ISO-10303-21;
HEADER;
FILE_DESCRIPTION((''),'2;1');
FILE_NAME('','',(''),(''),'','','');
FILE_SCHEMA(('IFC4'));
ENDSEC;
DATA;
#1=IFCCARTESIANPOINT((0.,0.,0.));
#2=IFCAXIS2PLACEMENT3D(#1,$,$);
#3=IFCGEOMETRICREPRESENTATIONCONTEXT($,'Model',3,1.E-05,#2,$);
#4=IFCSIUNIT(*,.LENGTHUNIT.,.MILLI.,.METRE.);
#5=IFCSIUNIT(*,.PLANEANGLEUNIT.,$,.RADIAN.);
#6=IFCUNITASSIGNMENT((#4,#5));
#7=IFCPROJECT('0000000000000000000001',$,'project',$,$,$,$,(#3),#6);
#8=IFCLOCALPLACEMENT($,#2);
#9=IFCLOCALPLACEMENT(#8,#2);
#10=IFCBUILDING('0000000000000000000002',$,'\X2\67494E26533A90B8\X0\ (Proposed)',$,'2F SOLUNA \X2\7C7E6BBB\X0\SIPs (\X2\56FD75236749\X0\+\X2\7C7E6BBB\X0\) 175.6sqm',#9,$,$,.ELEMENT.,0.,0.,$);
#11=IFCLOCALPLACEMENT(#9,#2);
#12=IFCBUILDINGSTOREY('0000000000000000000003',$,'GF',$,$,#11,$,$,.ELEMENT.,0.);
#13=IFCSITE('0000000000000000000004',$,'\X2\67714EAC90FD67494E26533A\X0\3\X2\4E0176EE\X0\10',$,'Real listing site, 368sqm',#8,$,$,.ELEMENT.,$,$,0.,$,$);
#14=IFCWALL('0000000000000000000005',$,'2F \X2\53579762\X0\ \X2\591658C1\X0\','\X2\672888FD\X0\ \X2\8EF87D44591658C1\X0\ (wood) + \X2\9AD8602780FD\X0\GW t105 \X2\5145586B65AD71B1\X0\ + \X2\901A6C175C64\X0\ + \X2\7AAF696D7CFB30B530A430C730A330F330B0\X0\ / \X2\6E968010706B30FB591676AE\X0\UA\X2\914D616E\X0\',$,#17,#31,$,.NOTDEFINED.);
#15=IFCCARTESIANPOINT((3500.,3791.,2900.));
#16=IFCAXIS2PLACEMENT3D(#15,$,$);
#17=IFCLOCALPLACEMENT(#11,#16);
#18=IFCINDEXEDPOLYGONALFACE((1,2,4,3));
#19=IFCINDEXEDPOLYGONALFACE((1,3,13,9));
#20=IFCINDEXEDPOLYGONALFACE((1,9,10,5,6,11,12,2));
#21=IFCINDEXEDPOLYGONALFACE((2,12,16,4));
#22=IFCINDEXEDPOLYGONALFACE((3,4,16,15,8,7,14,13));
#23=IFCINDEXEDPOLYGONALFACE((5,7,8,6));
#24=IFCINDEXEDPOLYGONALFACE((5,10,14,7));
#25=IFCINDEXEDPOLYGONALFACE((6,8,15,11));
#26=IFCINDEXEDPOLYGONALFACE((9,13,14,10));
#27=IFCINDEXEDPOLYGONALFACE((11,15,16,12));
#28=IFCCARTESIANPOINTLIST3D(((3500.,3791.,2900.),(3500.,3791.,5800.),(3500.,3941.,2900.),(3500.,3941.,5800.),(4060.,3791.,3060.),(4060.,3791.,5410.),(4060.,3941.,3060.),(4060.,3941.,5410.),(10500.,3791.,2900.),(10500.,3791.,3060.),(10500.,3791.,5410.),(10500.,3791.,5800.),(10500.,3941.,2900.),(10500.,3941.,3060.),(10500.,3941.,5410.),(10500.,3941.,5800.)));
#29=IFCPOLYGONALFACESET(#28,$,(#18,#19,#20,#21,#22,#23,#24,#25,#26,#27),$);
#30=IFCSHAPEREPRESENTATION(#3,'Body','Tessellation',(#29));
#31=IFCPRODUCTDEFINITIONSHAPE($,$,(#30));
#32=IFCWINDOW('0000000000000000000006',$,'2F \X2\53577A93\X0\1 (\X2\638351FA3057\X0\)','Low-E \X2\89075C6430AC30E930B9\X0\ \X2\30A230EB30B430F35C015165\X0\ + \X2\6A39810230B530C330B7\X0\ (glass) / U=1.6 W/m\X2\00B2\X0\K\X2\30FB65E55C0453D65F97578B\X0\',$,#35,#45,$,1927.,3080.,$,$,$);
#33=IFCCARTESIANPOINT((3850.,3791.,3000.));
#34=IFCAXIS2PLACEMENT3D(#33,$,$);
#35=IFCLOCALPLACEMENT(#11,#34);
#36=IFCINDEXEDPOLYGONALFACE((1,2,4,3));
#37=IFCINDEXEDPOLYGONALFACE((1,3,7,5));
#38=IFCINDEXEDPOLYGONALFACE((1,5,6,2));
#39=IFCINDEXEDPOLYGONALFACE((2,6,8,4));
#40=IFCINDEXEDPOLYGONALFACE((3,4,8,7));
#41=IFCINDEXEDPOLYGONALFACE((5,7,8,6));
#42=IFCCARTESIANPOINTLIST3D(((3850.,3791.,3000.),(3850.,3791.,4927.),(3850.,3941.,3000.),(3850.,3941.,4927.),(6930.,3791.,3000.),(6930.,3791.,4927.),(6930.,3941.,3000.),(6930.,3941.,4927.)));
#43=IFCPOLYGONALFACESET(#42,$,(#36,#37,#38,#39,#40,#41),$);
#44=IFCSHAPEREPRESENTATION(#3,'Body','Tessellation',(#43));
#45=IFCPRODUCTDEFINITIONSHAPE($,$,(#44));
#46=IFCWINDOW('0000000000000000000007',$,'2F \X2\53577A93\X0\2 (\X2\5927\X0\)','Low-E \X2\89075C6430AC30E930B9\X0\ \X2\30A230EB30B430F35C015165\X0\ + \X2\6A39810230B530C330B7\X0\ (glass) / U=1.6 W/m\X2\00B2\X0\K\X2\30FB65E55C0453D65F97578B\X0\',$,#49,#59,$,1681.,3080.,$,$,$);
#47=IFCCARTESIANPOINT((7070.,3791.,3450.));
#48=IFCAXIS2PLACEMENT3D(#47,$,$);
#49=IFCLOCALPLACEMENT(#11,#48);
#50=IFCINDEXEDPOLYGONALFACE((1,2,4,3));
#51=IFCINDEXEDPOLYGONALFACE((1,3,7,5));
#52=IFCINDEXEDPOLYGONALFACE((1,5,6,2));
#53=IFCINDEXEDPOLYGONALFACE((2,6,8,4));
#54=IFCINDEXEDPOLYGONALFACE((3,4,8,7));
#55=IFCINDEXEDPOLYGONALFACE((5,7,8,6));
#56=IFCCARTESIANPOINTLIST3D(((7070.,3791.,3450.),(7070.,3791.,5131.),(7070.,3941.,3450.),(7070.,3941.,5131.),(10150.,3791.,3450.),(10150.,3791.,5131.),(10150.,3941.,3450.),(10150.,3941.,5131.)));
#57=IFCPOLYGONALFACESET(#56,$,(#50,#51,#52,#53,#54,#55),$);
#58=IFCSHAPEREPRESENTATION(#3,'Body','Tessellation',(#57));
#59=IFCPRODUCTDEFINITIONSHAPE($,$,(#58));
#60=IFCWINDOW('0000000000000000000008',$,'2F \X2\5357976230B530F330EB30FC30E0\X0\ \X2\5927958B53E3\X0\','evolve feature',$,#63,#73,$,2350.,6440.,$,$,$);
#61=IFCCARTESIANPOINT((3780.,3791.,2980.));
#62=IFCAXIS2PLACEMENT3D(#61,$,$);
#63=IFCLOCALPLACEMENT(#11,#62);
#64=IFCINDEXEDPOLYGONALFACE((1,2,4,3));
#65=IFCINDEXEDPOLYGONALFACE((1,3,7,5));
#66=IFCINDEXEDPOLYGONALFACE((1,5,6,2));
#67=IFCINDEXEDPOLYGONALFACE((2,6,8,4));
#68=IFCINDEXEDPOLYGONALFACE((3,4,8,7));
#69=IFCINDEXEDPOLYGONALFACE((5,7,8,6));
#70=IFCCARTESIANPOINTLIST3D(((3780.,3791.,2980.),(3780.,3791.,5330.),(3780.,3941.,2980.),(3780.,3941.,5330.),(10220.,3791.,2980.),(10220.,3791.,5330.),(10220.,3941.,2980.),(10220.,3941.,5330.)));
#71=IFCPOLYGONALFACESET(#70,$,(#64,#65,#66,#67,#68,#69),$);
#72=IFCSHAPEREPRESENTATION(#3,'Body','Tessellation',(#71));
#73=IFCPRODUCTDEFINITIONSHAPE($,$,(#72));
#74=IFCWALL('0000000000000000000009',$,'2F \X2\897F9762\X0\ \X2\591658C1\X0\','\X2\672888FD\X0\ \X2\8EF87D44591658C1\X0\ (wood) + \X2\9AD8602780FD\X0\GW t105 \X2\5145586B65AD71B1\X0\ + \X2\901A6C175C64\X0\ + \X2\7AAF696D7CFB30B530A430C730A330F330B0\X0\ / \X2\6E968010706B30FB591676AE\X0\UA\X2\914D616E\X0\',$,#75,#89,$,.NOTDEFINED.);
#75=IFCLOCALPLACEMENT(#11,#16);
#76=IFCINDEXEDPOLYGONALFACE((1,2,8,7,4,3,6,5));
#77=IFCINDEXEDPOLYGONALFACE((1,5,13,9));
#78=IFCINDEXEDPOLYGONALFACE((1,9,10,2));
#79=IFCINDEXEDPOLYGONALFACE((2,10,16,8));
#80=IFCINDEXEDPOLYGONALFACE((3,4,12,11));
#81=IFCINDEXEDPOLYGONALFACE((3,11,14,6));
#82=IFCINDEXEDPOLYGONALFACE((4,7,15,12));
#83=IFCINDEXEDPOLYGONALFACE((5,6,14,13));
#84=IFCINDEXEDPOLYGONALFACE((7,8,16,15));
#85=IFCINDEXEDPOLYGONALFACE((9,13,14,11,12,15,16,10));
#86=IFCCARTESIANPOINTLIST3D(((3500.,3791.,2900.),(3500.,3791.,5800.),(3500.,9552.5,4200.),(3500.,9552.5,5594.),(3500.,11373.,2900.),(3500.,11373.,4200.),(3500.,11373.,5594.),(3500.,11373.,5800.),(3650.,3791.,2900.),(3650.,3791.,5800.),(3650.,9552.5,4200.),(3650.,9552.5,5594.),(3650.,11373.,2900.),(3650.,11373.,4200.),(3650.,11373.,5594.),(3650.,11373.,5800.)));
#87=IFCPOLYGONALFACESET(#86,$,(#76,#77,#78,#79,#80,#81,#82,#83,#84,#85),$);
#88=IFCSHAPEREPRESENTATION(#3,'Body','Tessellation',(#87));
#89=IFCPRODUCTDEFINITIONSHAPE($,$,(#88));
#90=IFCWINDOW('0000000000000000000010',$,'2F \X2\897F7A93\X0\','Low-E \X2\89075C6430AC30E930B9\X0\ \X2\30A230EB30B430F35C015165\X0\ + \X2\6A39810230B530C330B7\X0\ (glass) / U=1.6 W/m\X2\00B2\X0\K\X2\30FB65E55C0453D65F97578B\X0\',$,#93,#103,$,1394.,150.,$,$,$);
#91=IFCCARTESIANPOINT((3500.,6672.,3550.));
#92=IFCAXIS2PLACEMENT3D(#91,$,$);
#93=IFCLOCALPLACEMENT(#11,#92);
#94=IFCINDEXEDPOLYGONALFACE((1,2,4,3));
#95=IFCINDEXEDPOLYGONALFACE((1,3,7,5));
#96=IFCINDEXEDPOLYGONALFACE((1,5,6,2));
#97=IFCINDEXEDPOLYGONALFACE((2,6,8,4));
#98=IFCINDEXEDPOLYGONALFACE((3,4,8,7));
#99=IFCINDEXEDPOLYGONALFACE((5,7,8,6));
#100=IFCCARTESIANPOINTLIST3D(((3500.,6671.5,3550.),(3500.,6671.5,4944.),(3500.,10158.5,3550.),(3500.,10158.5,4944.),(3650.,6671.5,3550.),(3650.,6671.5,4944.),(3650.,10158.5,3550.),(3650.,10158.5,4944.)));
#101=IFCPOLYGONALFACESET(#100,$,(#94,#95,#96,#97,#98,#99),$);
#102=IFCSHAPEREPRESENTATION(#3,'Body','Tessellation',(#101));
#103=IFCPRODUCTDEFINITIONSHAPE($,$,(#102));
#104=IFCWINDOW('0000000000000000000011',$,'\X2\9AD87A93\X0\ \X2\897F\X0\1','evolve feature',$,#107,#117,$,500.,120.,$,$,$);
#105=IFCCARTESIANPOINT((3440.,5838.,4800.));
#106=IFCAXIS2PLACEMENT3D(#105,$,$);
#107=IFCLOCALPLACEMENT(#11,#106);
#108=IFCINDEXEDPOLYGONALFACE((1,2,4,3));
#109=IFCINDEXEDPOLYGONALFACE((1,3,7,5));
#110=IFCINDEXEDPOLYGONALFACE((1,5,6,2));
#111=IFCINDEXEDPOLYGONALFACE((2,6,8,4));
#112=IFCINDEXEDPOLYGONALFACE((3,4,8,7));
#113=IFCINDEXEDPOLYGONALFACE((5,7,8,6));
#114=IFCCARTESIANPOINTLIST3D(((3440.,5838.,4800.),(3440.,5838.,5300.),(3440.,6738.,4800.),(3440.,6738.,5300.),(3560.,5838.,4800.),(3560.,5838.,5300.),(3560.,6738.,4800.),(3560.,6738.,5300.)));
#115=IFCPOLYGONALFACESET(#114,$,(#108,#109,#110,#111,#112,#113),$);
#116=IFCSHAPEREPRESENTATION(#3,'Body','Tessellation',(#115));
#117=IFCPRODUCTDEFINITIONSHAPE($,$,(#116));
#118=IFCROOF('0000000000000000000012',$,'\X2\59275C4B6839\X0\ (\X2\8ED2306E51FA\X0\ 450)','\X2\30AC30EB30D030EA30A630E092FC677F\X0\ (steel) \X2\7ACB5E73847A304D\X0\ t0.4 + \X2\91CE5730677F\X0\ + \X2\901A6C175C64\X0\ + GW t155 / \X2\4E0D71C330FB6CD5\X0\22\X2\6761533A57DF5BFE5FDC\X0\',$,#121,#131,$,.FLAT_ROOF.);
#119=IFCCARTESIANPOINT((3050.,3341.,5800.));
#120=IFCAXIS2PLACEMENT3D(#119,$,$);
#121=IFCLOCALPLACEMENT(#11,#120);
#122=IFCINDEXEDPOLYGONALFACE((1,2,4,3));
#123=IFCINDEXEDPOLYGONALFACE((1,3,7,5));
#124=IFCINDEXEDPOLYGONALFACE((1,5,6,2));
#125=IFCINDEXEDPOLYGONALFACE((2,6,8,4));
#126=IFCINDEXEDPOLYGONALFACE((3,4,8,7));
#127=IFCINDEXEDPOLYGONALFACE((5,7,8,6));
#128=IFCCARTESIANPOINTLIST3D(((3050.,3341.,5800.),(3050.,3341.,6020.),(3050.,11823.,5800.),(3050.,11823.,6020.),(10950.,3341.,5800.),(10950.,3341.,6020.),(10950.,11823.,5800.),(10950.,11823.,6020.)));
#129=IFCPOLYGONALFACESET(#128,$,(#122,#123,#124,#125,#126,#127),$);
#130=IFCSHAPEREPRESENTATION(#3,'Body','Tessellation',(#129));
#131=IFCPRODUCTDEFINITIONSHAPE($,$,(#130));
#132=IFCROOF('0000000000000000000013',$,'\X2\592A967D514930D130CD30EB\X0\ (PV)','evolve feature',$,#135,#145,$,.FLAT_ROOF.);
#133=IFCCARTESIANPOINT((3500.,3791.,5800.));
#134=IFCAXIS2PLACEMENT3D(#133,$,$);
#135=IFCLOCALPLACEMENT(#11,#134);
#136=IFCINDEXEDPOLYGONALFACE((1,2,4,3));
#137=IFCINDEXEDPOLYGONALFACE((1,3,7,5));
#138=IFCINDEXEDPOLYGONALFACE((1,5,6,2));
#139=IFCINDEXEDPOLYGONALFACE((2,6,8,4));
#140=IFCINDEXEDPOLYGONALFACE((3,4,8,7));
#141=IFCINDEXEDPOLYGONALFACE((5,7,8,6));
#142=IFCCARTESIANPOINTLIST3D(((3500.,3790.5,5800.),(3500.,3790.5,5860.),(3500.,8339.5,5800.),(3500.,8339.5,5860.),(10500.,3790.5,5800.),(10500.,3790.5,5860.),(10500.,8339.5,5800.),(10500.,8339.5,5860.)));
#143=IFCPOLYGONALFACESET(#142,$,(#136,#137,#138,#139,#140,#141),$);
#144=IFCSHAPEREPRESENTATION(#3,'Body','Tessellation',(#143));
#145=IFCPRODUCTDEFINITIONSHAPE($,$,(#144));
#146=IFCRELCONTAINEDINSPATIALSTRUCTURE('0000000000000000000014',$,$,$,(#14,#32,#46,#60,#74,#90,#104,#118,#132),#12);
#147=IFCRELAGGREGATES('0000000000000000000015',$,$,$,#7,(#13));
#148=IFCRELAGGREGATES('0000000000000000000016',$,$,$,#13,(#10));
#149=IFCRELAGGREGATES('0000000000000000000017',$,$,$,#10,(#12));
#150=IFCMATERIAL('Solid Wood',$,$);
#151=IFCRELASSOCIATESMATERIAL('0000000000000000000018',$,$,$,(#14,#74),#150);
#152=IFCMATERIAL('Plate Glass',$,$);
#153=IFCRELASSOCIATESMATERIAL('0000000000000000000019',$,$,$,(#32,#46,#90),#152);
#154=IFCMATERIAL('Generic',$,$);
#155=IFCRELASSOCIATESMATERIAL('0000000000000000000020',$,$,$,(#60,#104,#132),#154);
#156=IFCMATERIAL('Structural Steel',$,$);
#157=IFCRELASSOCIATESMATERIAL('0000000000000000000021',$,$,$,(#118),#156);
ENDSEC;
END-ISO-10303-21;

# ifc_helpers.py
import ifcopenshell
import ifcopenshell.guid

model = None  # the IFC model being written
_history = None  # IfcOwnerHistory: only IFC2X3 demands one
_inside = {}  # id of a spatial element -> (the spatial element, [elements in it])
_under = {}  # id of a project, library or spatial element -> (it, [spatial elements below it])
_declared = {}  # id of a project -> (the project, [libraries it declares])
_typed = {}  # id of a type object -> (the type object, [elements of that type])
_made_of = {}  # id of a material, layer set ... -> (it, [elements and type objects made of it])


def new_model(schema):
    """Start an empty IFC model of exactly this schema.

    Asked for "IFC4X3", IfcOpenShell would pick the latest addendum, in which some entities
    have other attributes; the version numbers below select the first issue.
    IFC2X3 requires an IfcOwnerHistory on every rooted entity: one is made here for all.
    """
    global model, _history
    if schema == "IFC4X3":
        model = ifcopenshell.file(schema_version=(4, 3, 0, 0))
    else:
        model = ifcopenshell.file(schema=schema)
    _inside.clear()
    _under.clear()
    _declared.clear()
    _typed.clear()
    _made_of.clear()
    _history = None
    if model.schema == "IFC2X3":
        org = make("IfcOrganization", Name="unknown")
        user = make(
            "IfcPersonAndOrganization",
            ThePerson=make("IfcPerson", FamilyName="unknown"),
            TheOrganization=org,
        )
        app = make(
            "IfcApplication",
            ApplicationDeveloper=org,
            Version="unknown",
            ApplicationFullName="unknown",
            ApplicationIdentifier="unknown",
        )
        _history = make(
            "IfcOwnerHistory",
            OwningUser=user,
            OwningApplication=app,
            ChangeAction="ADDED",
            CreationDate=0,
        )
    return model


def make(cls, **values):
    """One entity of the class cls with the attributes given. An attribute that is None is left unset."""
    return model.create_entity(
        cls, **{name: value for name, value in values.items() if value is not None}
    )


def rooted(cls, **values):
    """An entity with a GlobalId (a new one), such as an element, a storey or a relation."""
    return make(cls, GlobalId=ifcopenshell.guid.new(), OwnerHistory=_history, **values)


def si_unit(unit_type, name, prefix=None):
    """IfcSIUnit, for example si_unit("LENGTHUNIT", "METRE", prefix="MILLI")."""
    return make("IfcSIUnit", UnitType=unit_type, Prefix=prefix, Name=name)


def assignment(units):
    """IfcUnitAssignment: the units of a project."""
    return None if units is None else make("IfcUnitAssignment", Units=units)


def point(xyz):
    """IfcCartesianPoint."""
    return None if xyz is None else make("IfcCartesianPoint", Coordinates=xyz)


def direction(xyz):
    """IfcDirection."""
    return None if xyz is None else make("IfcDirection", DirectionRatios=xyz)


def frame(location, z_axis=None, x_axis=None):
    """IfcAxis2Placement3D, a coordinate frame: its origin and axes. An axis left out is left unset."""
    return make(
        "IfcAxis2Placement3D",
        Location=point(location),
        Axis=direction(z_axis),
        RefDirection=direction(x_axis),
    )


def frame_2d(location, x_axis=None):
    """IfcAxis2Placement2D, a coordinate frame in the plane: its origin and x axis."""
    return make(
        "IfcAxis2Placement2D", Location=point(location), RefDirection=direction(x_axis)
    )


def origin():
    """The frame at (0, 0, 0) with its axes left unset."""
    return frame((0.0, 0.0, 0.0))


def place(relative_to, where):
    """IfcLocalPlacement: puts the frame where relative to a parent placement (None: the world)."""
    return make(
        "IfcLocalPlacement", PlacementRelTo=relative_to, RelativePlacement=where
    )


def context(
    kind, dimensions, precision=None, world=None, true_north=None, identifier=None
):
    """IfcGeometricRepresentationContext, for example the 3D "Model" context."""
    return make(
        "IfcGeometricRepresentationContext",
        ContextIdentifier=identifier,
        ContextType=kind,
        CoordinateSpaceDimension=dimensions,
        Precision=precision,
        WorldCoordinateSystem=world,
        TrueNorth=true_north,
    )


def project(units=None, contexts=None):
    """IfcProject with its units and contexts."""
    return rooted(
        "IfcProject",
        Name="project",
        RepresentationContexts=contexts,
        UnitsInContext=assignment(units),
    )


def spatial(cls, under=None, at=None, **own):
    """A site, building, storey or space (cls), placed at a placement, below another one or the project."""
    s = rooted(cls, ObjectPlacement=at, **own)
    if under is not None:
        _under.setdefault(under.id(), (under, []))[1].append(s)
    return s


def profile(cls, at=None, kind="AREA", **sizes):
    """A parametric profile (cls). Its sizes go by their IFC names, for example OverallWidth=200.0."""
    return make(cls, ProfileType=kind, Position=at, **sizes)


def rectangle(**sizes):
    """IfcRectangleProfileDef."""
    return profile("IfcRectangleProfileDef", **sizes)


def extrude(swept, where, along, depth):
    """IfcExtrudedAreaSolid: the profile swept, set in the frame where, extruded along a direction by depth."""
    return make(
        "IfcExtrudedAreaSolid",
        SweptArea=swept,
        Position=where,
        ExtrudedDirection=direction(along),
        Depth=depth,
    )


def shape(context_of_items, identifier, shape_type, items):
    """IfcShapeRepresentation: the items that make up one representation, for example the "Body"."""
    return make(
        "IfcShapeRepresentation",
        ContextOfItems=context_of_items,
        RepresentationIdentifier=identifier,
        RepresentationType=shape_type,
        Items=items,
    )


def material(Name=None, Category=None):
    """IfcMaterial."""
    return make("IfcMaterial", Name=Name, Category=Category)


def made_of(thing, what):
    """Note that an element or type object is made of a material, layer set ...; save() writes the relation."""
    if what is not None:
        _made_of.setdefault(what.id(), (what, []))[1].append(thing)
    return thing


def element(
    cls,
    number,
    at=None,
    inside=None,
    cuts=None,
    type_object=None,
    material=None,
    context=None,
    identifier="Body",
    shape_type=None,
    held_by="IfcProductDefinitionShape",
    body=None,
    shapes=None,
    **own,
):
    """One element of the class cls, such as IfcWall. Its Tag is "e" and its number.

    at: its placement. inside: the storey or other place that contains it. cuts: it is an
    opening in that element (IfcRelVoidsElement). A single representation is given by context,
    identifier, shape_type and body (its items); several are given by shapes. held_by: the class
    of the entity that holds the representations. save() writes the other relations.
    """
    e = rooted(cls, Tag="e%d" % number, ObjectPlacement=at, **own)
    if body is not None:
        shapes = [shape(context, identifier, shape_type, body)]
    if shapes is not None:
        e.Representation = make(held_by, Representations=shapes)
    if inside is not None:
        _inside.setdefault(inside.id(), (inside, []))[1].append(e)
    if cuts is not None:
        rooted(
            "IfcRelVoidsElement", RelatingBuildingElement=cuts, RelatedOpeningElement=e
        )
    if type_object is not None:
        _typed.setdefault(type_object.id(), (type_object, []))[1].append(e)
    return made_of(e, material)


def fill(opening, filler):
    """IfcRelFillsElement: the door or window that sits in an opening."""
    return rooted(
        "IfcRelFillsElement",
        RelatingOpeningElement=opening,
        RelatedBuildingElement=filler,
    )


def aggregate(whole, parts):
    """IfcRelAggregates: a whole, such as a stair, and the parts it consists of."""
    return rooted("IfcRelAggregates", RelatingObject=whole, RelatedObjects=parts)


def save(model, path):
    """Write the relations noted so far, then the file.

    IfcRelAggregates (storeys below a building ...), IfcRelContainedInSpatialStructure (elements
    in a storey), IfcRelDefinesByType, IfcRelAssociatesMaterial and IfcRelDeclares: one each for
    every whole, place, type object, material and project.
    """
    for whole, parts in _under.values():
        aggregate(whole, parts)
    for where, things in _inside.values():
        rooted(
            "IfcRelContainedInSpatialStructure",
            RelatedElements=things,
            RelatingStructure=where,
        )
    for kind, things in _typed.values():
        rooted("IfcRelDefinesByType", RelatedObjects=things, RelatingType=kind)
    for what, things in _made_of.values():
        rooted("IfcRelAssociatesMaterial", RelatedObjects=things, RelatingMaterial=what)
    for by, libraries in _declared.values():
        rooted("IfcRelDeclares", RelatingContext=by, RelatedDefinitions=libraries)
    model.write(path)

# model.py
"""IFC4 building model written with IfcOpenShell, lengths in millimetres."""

from ifc_helpers import new_model, si_unit, frame, frame_2d, origin, place, context, project, spatial, rectangle, extrude, material, element, fill, save


model = new_model("IFC4")

# Units and contexts
model_context = context("Model", 3, precision=1e-05, world=origin())
ifc_project = project(units=[si_unit("LENGTHUNIT", "METRE", prefix="MILLI"), si_unit("PLANEANGLEUNIT", "RADIAN")], contexts=[model_context])

# Site, building, storey
site_placement = place(None, origin())
site = spatial("IfcSite", under=ifc_project, at=site_placement, Name="東京都杉並区3丁目10", ObjectType="Real listing site, 368sqm", CompositionType="ELEMENT", RefElevation=0.0)
building_placement = place(site_placement, origin())
building = spatial("IfcBuilding", under=site, at=building_placement, Name="杉並区邸 (Proposed)", ObjectType="2F SOLUNA 籾殻SIPs (国産杉+籾殻) 175.6sqm", CompositionType="ELEMENT", ElevationOfRefHeight=0.0, ElevationOfTerrain=0.0)
storey_placement = place(building_placement, origin())
storey = spatial("IfcBuildingStorey", under=building, at=storey_placement, Name="GF", CompositionType="ELEMENT", Elevation=0.0)

# Shared definitions
ifc_material_1 = material(Name="Solid Wood")
ifc_material_2 = material(Name="Generic")

# Shared definitions
ifc_material_3 = material(Name="Plate Glass")

# Walls, openings, windows
wall_1_placement = place(storey_placement, frame((3500.0, 3791.0, 2900.0)))
wall_1 = element("IfcWall", 1, at=wall_1_placement, inside=storey, material=ifc_material_1, Name="2F 南面 外壁", Description="木製 軸組外壁 (wood) + 高性能GW t105 充填断熱 + 通気層 + 窯業系サイディング / 準耐火・外皮UA配慮", PredefinedType="NOTDEFINED", context=model_context, shape_type="SweptSolid", body=[
    extrude(rectangle(XDim=7000.0, YDim=150.0, at=frame_2d((3500.0, 75.0))), frame((3500.0, 3791.0, 2900.0)), (0.0, 0.0, 1.0), 2900.0),
])
opening_1_placement = place(storey_placement, frame((3850.0, 3791.0, 3000.0)))
opening_1 = element("IfcOpeningElement", 2, at=opening_1_placement, cuts=wall_1, PredefinedType="NOTDEFINED", context=model_context, shape_type="SweptSolid", body=[
    extrude(rectangle(XDim=3080.0, YDim=150.0, at=frame_2d((1540.0, 75.0))), frame((3850.0, 3791.0, 3000.0)), (0.0, 0.0, 1.0), 1927.0),
])
opening_2_placement = place(storey_placement, frame((7070.0, 3791.0, 3450.0)))
opening_2 = element("IfcOpeningElement", 3, at=opening_2_placement, cuts=wall_1, PredefinedType="NOTDEFINED", context=model_context, shape_type="SweptSolid", body=[
    extrude(rectangle(XDim=3080.0, YDim=150.0, at=frame_2d((1540.0, 75.0))), frame((7070.0, 3791.0, 3450.0)), (0.0, 0.0, 1.0), 1681.0),
])
opening_3_placement = place(storey_placement, frame((3780.0, 3791.0, 2980.0)))
opening_3 = element("IfcOpeningElement", 4, at=opening_3_placement, cuts=wall_1, PredefinedType="NOTDEFINED", context=model_context, shape_type="SweptSolid", body=[
    extrude(rectangle(XDim=6440.0, YDim=150.0, at=frame_2d((3220.0, 75.0))), frame((3780.0, 3791.0, 2980.0)), (0.0, 0.0, 1.0), 2350.0),
])
window_1_placement = place(storey_placement, frame((3850.0, 3791.0, 3000.0)))
window_1 = element("IfcWindow", 5, at=window_1_placement, inside=storey, material=ifc_material_3, Name="2F 南窓1 (掃出し)", Description="Low-E 複層ガラス アルゴン封入 + 樹脂サッシ (glass) / U=1.6 W/m²K・日射取得型", OverallHeight=1927.0, OverallWidth=3080.0, context=model_context, shape_type="SweptSolid", body=[
    extrude(rectangle(XDim=3080.0, YDim=150.0, at=frame_2d((1540.0, 75.0))), frame((3850.0, 3791.0, 3000.0)), (0.0, 0.0, 1.0), 1927.0),
])
fill(opening_1, window_1)
window_2_placement = place(storey_placement, frame((7070.0, 3791.0, 3450.0)))
window_2 = element("IfcWindow", 6, at=window_2_placement, inside=storey, material=ifc_material_3, Name="2F 南窓2 (大)", Description="Low-E 複層ガラス アルゴン封入 + 樹脂サッシ (glass) / U=1.6 W/m²K・日射取得型", OverallHeight=1681.0, OverallWidth=3080.0, context=model_context, shape_type="SweptSolid", body=[
    extrude(rectangle(XDim=3080.0, YDim=150.0, at=frame_2d((1540.0, 75.0))), frame((7070.0, 3791.0, 3450.0)), (0.0, 0.0, 1.0), 1681.0),
])
fill(opening_2, window_2)
window_3_placement = place(storey_placement, frame((3780.0, 3791.0, 2980.0)))
window_3 = element("IfcWindow", 7, at=window_3_placement, inside=storey, material=ifc_material_2, Name="2F 南面サンルーム 大開口", Description="evolve feature", OverallHeight=2350.0, OverallWidth=6440.0, context=model_context, shape_type="SweptSolid", body=[
    extrude(rectangle(XDim=6440.0, YDim=150.0, at=frame_2d((3220.0, 75.0))), frame((3780.0, 3791.0, 2980.0)), (0.0, 0.0, 1.0), 2350.0),
])
fill(opening_3, window_3)
wall_2_placement = place(storey_placement, frame((3500.0, 3791.0, 2900.0)))
wall_2 = element("IfcWall", 8, at=wall_2_placement, inside=storey, material=ifc_material_1, Name="2F 西面 外壁", Description="木製 軸組外壁 (wood) + 高性能GW t105 充填断熱 + 通気層 + 窯業系サイディング / 準耐火・外皮UA配慮", PredefinedType="NOTDEFINED", context=model_context, shape_type="SweptSolid", body=[
    extrude(rectangle(XDim=150.0, YDim=7582.0, at=frame_2d((75.0, 3791.0))), frame((3500.0, 3791.0, 2900.0)), (0.0, 0.0, 1.0), 2900.0),
])
opening_4_placement = place(storey_placement, frame((3500.0, 6672.0, 3550.0)))
opening_4 = element("IfcOpeningElement", 9, at=opening_4_placement, cuts=wall_2, PredefinedType="NOTDEFINED", context=model_context, shape_type="SweptSolid", body=[
    extrude(rectangle(XDim=150.0, YDim=3487.0, at=frame_2d((75.0, 1743.0))), frame((3500.0, 6672.0, 3550.0)), (0.0, 0.0, 1.0), 1394.0),
])
opening_5_placement = place(storey_placement, frame((3440.0, 5838.0, 4800.0)))
opening_5 = element("IfcOpeningElement", 10, at=opening_5_placement, cuts=wall_2, PredefinedType="NOTDEFINED", context=model_context, shape_type="SweptSolid", body=[
    extrude(rectangle(XDim=120.0, YDim=900.0, at=frame_2d((60.0, 450.0))), frame((3440.0, 5838.0, 4800.0)), (0.0, 0.0, 1.0), 500.0),
])
window_4_placement = place(storey_placement, frame((3500.0, 6672.0, 3550.0)))
window_4 = element("IfcWindow", 11, at=window_4_placement, inside=storey, material=ifc_material_3, Name="2F 西窓", Description="Low-E 複層ガラス アルゴン封入 + 樹脂サッシ (glass) / U=1.6 W/m²K・日射取得型", OverallHeight=1394.0, OverallWidth=150.0, context=model_context, shape_type="SweptSolid", body=[
    extrude(rectangle(XDim=150.0, YDim=3487.0, at=frame_2d((75.0, 1743.0))), frame((3500.0, 6672.0, 3550.0)), (0.0, 0.0, 1.0), 1394.0),
])
fill(opening_4, window_4)
window_5_placement = place(storey_placement, frame((3440.0, 5838.0, 4800.0)))
window_5 = element("IfcWindow", 12, at=window_5_placement, inside=storey, material=ifc_material_2, Name="高窓 西1", Description="evolve feature", OverallHeight=500.0, OverallWidth=120.0, context=model_context, shape_type="SweptSolid", body=[
    extrude(rectangle(XDim=120.0, YDim=900.0, at=frame_2d((60.0, 450.0))), frame((3440.0, 5838.0, 4800.0)), (0.0, 0.0, 1.0), 500.0),
])
fill(opening_5, window_5)

# Roofs
ifc_material_4 = material(Name="Structural Steel")
roof_1_placement = place(storey_placement, frame((3050.0, 3341.0, 5800.0)))
element("IfcRoof", 13, at=roof_1_placement, inside=storey, material=ifc_material_4, Name="大屋根 (軒の出 450)", Description="ガルバリウム鋼板 (steel) 立平葺き t0.4 + 野地板 + 通気層 + GW t155 / 不燃・法22条区域対応", PredefinedType="FLAT_ROOF", context=model_context, shape_type="SweptSolid", body=[
    extrude(rectangle(XDim=7900.0, YDim=8482.0, at=frame_2d((3950.0, 4241.0))), frame((3050.0, 3341.0, 5800.0)), (0.0, 0.0, 1.0), 220.0),
])
roof_2_placement = place(storey_placement, frame((3500.0, 3791.0, 5800.0)))
element("IfcRoof", 14, at=roof_2_placement, inside=storey, material=ifc_material_2, Name="太陽光パネル (PV)", Description="evolve feature", PredefinedType="FLAT_ROOF", context=model_context, shape_type="SweptSolid", body=[
    extrude(rectangle(XDim=7000.0, YDim=4549.0, at=frame_2d((3500.0, 2274.0))), frame((3500.0, 3791.0, 5800.0)), (0.0, 0.0, 1.0), 60.0),
])

save(model, "model.ifc")
